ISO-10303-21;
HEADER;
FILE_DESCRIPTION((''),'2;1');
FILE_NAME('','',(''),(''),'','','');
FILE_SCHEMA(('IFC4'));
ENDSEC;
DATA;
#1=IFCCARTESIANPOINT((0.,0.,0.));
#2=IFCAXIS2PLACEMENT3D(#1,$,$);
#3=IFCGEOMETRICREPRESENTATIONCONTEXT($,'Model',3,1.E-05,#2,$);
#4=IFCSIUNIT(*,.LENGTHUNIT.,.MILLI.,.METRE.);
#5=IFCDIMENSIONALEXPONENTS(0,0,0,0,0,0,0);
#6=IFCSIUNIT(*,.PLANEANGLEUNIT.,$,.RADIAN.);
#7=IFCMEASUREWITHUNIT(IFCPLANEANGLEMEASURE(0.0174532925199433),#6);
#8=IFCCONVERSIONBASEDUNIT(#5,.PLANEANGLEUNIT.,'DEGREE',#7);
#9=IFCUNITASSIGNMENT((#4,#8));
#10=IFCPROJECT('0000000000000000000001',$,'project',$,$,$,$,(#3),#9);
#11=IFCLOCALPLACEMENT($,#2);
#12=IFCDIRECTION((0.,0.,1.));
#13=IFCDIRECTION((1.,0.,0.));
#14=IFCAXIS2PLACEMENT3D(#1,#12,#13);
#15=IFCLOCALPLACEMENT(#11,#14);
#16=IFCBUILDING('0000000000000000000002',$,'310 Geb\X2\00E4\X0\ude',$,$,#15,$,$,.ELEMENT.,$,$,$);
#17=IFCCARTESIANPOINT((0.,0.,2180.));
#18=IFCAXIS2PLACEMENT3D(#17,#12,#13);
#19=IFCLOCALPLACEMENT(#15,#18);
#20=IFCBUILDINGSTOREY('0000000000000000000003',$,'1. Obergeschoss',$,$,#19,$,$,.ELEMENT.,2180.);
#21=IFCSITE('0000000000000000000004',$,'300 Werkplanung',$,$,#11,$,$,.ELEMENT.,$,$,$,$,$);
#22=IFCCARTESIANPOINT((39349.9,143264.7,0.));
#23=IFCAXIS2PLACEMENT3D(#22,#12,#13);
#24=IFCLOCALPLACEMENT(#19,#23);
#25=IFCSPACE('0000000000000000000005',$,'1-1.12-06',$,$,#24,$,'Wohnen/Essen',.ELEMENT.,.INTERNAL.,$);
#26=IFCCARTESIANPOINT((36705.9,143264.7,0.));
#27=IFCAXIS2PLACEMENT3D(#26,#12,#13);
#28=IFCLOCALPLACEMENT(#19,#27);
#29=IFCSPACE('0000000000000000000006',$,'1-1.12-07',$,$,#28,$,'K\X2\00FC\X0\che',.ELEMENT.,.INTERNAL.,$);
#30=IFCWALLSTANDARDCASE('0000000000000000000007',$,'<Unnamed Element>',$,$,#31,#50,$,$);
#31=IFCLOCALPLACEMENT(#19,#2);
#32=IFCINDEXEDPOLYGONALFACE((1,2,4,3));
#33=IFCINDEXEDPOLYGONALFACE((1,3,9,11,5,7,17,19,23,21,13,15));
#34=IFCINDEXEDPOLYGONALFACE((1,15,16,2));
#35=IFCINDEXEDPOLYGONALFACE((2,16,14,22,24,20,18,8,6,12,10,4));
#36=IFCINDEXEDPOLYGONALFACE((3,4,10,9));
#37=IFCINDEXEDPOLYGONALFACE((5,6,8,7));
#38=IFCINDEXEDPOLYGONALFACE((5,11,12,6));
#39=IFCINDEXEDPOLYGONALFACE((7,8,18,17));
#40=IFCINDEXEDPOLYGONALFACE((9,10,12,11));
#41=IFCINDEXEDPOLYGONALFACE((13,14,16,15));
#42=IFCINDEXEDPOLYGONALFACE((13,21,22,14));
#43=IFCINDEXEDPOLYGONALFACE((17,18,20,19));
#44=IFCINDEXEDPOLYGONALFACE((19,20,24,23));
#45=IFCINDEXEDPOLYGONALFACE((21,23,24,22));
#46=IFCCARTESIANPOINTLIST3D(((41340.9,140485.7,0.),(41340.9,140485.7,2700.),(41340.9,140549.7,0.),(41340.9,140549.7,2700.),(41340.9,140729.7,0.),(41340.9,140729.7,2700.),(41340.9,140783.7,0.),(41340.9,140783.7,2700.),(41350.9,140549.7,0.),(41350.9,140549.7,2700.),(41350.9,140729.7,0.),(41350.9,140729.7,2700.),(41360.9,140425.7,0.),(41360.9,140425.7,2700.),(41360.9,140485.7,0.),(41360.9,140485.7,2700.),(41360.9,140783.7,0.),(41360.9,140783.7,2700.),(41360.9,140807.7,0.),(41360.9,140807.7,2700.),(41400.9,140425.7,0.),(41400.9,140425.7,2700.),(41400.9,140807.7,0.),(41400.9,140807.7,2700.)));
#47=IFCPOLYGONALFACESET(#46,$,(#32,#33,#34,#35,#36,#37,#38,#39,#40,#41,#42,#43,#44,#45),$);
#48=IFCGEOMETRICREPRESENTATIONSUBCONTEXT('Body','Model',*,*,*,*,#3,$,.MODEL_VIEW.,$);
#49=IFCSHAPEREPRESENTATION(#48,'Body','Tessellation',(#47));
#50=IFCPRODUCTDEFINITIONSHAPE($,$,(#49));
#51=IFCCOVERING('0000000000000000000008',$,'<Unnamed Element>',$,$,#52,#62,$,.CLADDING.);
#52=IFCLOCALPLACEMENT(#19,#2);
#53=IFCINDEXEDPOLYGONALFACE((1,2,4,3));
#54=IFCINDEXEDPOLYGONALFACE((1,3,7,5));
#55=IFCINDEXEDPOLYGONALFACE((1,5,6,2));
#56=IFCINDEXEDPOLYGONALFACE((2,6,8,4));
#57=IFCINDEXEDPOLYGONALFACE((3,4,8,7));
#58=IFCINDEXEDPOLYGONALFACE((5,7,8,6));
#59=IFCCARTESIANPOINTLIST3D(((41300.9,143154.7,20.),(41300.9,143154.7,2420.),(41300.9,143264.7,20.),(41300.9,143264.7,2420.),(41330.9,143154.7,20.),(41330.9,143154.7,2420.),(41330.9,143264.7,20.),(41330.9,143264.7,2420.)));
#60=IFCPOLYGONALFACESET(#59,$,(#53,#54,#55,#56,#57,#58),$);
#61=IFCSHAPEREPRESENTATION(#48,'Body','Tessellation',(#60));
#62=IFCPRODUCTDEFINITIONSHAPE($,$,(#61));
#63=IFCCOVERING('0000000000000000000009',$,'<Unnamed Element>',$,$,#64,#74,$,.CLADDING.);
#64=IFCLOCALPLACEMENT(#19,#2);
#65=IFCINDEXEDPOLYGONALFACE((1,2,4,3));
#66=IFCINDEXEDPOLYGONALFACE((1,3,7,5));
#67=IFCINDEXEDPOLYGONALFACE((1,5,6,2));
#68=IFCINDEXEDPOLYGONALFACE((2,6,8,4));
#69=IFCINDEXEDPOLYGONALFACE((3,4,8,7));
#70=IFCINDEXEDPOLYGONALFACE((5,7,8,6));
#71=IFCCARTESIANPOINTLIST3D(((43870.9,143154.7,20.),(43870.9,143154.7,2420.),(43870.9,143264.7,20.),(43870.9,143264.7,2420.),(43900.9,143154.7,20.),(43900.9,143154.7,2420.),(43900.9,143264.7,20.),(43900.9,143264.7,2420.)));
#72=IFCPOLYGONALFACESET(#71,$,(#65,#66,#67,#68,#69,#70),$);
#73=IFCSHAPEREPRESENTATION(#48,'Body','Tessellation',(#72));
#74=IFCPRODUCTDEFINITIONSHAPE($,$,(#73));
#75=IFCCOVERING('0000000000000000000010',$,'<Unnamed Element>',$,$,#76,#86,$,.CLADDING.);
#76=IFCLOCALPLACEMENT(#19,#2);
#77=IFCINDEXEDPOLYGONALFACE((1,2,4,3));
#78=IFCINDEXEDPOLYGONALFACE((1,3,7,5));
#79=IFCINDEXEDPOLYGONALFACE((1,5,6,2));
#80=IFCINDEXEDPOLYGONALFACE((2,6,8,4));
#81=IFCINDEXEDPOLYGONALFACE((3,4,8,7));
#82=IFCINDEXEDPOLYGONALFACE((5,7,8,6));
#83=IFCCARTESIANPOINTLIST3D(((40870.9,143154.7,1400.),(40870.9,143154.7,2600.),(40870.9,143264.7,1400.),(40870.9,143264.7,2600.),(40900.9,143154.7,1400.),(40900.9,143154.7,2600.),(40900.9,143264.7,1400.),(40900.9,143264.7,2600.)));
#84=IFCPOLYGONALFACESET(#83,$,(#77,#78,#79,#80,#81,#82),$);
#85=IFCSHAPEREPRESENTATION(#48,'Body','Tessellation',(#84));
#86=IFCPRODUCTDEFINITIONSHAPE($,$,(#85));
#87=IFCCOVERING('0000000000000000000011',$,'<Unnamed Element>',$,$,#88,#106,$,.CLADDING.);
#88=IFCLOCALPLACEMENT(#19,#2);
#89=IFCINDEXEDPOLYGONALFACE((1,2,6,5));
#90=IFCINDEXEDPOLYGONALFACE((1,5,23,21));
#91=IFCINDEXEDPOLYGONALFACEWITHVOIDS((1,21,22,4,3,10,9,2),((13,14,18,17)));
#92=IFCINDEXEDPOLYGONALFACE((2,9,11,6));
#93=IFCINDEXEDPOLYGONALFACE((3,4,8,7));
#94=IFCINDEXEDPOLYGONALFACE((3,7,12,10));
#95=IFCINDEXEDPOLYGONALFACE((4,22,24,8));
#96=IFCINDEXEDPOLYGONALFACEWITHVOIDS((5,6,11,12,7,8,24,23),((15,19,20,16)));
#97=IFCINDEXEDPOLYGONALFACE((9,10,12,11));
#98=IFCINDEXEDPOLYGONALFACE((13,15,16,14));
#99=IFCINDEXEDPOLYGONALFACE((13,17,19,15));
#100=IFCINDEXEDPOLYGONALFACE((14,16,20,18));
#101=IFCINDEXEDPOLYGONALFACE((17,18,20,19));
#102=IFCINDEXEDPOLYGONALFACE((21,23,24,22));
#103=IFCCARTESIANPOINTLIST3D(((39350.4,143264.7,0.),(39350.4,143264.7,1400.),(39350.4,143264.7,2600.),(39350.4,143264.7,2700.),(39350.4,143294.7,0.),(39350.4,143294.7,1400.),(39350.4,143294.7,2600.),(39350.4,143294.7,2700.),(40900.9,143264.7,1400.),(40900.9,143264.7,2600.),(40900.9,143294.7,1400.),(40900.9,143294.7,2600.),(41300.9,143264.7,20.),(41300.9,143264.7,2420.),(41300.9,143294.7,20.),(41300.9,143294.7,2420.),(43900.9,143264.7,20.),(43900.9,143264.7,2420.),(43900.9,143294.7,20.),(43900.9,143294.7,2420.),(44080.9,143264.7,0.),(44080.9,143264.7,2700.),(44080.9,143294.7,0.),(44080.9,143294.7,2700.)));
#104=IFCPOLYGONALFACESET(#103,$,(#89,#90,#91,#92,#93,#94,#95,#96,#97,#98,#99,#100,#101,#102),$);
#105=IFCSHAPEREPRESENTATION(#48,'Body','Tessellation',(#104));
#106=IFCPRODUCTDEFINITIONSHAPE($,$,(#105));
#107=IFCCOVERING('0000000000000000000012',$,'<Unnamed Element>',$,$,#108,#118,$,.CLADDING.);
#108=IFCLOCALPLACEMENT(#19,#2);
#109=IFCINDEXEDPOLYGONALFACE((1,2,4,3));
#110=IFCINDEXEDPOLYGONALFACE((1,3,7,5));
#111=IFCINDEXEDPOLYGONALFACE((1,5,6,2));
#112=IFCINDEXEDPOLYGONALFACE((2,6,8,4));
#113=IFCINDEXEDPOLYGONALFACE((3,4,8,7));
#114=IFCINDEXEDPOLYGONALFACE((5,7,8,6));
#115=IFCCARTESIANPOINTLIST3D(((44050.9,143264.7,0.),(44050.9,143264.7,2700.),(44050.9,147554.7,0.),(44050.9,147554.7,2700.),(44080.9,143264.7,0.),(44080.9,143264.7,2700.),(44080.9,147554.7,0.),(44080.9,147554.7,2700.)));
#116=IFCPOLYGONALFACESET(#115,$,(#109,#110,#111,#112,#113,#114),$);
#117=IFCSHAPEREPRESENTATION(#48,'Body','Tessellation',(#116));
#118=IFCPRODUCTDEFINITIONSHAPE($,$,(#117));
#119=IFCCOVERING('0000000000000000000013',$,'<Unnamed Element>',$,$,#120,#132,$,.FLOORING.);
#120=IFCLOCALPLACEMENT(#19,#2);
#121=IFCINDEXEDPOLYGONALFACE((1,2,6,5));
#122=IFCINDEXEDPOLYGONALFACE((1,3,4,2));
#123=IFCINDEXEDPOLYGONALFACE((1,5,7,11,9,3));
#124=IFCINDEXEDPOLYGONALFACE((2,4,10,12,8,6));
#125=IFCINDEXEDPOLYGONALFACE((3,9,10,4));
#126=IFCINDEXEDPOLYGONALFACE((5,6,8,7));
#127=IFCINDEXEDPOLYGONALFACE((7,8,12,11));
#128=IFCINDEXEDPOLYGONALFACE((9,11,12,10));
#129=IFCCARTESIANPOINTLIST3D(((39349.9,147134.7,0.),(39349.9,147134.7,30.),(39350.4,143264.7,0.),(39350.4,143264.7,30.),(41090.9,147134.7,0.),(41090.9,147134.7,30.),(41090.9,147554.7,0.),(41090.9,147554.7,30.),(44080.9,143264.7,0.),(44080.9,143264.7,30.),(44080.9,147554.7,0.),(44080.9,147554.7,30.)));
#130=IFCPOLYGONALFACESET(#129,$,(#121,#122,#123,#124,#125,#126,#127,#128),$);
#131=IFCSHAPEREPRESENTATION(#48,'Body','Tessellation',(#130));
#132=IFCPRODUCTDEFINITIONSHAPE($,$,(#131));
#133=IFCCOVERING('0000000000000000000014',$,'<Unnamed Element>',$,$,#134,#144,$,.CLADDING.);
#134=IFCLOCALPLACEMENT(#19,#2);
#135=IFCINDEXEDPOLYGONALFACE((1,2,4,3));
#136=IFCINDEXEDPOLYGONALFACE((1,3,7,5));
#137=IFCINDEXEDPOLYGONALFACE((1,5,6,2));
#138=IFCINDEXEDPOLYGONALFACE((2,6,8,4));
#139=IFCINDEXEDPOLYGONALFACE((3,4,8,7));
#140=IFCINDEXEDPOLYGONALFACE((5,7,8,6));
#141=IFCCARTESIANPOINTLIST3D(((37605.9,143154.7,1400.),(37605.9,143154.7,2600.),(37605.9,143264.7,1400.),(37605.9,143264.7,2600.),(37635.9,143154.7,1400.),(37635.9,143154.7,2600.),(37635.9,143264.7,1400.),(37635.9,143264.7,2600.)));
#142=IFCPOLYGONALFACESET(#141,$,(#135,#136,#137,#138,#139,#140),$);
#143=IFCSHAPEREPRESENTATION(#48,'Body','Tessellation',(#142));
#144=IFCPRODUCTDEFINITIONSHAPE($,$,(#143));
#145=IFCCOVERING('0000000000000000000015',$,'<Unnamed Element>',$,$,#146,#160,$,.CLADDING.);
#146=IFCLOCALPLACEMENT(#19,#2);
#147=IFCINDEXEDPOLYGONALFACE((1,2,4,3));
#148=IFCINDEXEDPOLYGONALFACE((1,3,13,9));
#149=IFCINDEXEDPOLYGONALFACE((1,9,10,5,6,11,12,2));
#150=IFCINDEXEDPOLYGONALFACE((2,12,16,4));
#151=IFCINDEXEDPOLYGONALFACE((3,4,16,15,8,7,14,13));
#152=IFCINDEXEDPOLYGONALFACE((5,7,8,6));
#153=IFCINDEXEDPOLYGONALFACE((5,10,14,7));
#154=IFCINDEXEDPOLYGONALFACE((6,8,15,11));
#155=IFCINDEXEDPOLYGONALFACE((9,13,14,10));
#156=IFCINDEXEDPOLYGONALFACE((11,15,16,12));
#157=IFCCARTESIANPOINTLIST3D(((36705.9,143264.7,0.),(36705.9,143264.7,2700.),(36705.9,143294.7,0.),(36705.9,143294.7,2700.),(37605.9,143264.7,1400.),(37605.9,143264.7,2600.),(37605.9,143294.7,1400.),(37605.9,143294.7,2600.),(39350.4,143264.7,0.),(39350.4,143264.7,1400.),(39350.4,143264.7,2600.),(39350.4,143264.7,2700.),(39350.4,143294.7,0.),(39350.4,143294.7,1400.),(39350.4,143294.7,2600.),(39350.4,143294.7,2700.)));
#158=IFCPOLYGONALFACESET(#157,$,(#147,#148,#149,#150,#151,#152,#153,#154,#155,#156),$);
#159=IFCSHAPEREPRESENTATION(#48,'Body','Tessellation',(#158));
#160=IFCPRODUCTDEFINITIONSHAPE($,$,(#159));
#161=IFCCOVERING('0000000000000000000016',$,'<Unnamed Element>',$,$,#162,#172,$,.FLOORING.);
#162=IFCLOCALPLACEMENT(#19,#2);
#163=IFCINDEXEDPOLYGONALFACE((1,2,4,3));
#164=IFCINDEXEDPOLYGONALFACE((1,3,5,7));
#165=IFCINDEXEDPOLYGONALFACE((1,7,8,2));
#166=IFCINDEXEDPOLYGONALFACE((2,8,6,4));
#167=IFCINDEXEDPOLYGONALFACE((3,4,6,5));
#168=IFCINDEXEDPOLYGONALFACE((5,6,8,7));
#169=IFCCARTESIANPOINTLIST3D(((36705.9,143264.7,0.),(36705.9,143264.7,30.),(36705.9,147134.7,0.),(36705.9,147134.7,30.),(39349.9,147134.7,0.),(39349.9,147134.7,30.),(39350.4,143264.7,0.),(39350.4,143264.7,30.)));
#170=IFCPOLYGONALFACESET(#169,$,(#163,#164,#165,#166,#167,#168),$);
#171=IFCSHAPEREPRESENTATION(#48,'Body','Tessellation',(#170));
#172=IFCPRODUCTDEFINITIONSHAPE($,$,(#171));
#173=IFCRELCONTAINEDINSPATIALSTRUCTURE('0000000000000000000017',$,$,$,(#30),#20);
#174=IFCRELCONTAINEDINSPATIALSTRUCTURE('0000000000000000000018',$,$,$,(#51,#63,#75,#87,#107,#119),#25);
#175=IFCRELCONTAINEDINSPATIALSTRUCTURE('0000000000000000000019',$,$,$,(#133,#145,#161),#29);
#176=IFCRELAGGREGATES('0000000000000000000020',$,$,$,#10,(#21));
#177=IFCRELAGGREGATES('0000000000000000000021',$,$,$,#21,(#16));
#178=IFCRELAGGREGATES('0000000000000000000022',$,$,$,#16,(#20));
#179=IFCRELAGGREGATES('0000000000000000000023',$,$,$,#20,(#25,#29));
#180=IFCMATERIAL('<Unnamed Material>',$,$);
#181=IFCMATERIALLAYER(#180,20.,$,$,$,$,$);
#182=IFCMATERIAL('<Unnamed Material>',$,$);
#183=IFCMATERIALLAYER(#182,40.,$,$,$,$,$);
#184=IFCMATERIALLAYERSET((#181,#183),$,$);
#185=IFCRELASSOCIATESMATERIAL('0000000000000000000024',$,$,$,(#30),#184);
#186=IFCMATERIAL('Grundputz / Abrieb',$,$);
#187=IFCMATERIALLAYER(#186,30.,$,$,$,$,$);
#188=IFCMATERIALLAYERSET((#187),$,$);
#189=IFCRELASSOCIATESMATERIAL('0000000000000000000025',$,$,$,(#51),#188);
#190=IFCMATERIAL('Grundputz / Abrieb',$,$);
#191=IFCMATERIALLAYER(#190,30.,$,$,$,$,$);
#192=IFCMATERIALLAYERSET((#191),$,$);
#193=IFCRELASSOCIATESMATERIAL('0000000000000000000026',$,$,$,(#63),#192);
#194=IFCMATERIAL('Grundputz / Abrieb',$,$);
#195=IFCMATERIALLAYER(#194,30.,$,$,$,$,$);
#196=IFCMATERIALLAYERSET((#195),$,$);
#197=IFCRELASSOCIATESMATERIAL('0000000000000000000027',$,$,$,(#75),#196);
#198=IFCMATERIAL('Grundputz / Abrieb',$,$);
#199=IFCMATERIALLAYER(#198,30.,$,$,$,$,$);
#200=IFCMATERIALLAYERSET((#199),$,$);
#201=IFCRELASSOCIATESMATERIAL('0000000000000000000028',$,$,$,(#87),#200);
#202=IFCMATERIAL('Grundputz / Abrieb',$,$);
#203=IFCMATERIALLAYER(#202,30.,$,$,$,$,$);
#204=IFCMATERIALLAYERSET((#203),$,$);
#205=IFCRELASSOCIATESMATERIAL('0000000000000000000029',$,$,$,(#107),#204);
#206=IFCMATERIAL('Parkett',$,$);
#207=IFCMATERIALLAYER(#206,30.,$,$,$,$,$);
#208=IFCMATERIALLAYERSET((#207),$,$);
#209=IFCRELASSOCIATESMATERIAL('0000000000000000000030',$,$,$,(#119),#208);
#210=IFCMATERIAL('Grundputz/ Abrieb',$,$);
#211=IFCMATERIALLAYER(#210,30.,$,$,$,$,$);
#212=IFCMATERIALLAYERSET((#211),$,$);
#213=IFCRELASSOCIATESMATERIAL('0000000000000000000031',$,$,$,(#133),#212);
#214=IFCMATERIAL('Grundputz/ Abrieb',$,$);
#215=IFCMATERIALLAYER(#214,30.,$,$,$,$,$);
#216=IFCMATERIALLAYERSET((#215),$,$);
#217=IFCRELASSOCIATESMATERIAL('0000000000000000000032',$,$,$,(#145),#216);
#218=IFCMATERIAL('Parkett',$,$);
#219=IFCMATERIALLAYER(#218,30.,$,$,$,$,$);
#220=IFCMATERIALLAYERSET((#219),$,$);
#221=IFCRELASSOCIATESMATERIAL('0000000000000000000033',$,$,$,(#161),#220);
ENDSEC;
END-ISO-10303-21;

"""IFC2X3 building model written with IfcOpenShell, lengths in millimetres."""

from ifc_helpers import new_model, entity, si_unit, converted_unit, frame, frame_2d, origin, origin_with_axes, place, context, subcontext, project, spatial, polyline, rectangle, outline, extrude, material, layer, layer_set, layer_usage, element, save


model = new_model("IFC2X3")

# Units and contexts
model_context = context("Model", 3, precision=1e-05, world=origin())
body_context = subcontext(model_context, "Body", "Model", "MODEL_VIEW")
ifc_project = project(units=[si_unit("LENGTHUNIT", "METRE", prefix="MILLI"), converted_unit("PLANEANGLEUNIT", "DEGREE", entity("IfcPlaneAngleMeasure", 0.0174532925199433), si_unit("PLANEANGLEUNIT", "RADIAN"), dimensions=[0, 0, 0, 0, 0, 0, 0])], contexts=[model_context])

# Site, building, storey
site_placement = place(None, origin())
site = spatial("IfcSite", under=ifc_project, at=site_placement, Name="300 Werkplanung", CompositionType="ELEMENT")
building_placement = place(site_placement, origin_with_axes())
building = spatial("IfcBuilding", under=site, at=building_placement, Name="310 Gebäude", CompositionType="ELEMENT")
storey_placement = place(building_placement, frame((0.0, 0.0, 2180.0), z_axis=(0.0, 0.0, 1.0), x_axis=(1.0, 0.0, 0.0)))
storey = spatial("IfcBuildingStorey", under=building, at=storey_placement, Name="1. Obergeschoss", CompositionType="ELEMENT", Elevation=2180.0)

# Wall
ifc_material_1 = material(Name="<Unnamed Material>")
ifc_layer_1 = layer(ifc_material_1, 20.0)
ifc_material_2 = material(Name="<Unnamed Material>")
ifc_layer_2 = layer(ifc_material_2, 40.0)
ifc_layer_set_1 = layer_set([ifc_layer_1, ifc_layer_2])
ifc_layer_usage_1 = layer_usage(ifc_layer_set_1, "AXIS2", "POSITIVE", -60.0)
wall_1_placement = place(storey_placement, frame((41340.9, 140783.7, 0.0), z_axis=(0.0, 0.0, 1.0), x_axis=(0.0, -1.0, 0.0)))
element("IfcWallStandardCase", 1, at=wall_1_placement, inside=storey, material=ifc_layer_usage_1, Name="<Unnamed Element>", context=body_context, shape_type="SweptSolid", body=[
    extrude(outline(polyline([(234.0, 0.0), (298.0, 0.0), (298.0, 20.0), (358.0, 20.0), (358.0, 60.0), (-24.0, 60.0), (-24.0, 20.0), (0.0, 20.0), (0.0, 0.0), (54.0, 0.0), (54.0, 10.0), (234.0, 10.0), (234.0, 0.0)])), origin_with_axes(), (0.0, 0.0, 1.0), 2700.0),
])

# Shared definitions
space_1_placement = place(storey_placement, frame((39349.9, 143264.7, 0.0), z_axis=(0.0, 0.0, 1.0), x_axis=(1.0, 0.0, 0.0)))
space_1 = spatial("IfcSpace", under=storey, at=space_1_placement, Name="1-1.12-06", LongName="Wohnen/Essen", CompositionType="ELEMENT", InteriorOrExteriorSpace="INTERNAL")

# Coverings
ifc_material_3 = material(Name="Grundputz / Abrieb")
ifc_layer_3 = layer(ifc_material_3, 30.0)
ifc_layer_set_2 = layer_set([ifc_layer_3])
ifc_layer_usage_2 = layer_usage(ifc_layer_set_2, "AXIS3", "POSITIVE", 0.0)
covering_1_placement = place(space_1_placement, frame((1951.0, 0.0, 20.0), z_axis=(0.0, 0.0, 1.0), x_axis=(0.0, -1.0, 0.0)))
element("IfcCovering", 2, at=covering_1_placement, inside=space_1, material=ifc_layer_usage_2, Name="<Unnamed Element>", PredefinedType="CLADDING", context=body_context, shape_type="SweptSolid", body=[
    extrude(rectangle(XDim=2400.0, YDim=110.0, at=frame_2d((-55.0, 1200.0), x_axis=(0.0, 1.0))), frame((110.0, 0.0, 2400.0), z_axis=(0.0, 1.0, 0.0), x_axis=(1.0, 0.0, 0.0)), (0.0, 0.0, 1.0), 30.0),
])
ifc_material_4 = material(Name="Grundputz / Abrieb")
ifc_layer_4 = layer(ifc_material_4, 30.0)
ifc_layer_set_3 = layer_set([ifc_layer_4])
ifc_layer_usage_3 = layer_usage(ifc_layer_set_3, "AXIS3", "POSITIVE", 0.0)
covering_2_placement = place(space_1_placement, frame((4551.0, -110.0, 20.0), z_axis=(0.0, 0.0, 1.0), x_axis=(0.0, 1.0, 0.0)))
element("IfcCovering", 3, at=covering_2_placement, inside=space_1, material=ifc_layer_usage_3, Name="<Unnamed Element>", PredefinedType="CLADDING", context=body_context, shape_type="SweptSolid", body=[
    extrude(rectangle(XDim=2400.0, YDim=110.0, at=frame_2d((-55.0, 1200.0), x_axis=(0.0, 1.0))), frame((110.0, 0.0, 2400.0), z_axis=(0.0, 1.0, 0.0), x_axis=(1.0, 0.0, 0.0)), (0.0, 0.0, 1.0), 30.0),
])
ifc_material_5 = material(Name="Grundputz / Abrieb")
ifc_layer_5 = layer(ifc_material_5, 30.0)
ifc_layer_set_4 = layer_set([ifc_layer_5])
ifc_layer_usage_4 = layer_usage(ifc_layer_set_4, "AXIS3", "POSITIVE", 0.0)
covering_3_placement = place(space_1_placement, frame((1551.0, -110.0, 1400.0), z_axis=(0.0, 0.0, 1.0), x_axis=(0.0, 1.0, 0.0)))
element("IfcCovering", 4, at=covering_3_placement, inside=space_1, material=ifc_layer_usage_4, Name="<Unnamed Element>", PredefinedType="CLADDING", context=body_context, shape_type="SweptSolid", body=[
    extrude(rectangle(XDim=1200.0, YDim=110.0, at=frame_2d((-55.0, 600.0), x_axis=(0.0, 1.0))), frame((110.0, 0.0, 1200.0), z_axis=(0.0, 1.0, 0.0), x_axis=(1.0, 0.0, 0.0)), (0.0, 0.0, 1.0), 30.0),
])
ifc_material_6 = material(Name="Grundputz / Abrieb")
ifc_layer_6 = layer(ifc_material_6, 30.0)
ifc_layer_set_5 = layer_set([ifc_layer_6])
ifc_layer_usage_5 = layer_usage(ifc_layer_set_5, "AXIS3", "POSITIVE", 0.0)
covering_4_placement = place(space_1_placement, frame((0.5, 0.0, 0.0), z_axis=(0.0, 0.0, 1.0), x_axis=(1.0, 0.0, 0.0)))
element("IfcCovering", 5, at=covering_4_placement, inside=space_1, material=ifc_layer_usage_5, Name="<Unnamed Element>", PredefinedType="CLADDING", context=body_context, shape_type="SweptSolid", body=[
    extrude(outline(polyline([(4730.5, 0.0), (4730.5, -2700.0), (0.0, -2700.0), (0.0, -2600.0), (1550.5, -2600.0), (1550.5, -1400.0), (0.0, -1400.0), (0.0, 0.0), (4730.5, 0.0)]), holes=[polyline([(4550.5, -20.0), (1950.5, -20.0), (1950.5, -2420.0), (4550.5, -2420.0), (4550.5, -20.0)])]), frame((0.0, 0.0, 0.0), z_axis=(0.0, 1.0, 0.0), x_axis=(1.0, 0.0, 0.0)), (0.0, 0.0, 1.0), 30.0),
])
ifc_material_7 = material(Name="Grundputz / Abrieb")
ifc_layer_7 = layer(ifc_material_7, 30.0)
ifc_layer_set_6 = layer_set([ifc_layer_7])
ifc_layer_usage_6 = layer_usage(ifc_layer_set_6, "AXIS3", "POSITIVE", 0.0)
covering_5_placement = place(space_1_placement, frame((4731.0, 0.0, 0.0), z_axis=(0.0, 0.0, 1.0), x_axis=(0.0, 1.0, 0.0)))
element("IfcCovering", 6, at=covering_5_placement, inside=space_1, material=ifc_layer_usage_6, Name="<Unnamed Element>", PredefinedType="CLADDING", context=body_context, shape_type="SweptSolid", body=[
    extrude(rectangle(XDim=2700.0, YDim=4290.0, at=frame_2d((-2145.0, 1350.0), x_axis=(0.0, 1.0))), frame((4290.0, 0.0, 2700.0), z_axis=(0.0, 1.0, 0.0), x_axis=(1.0, 0.0, 0.0)), (0.0, 0.0, 1.0), 30.0),
])
ifc_material_8 = material(Name="Parkett")
ifc_layer_8 = layer(ifc_material_8, 30.0)
ifc_layer_set_7 = layer_set([ifc_layer_8])
ifc_layer_usage_7 = layer_usage(ifc_layer_set_7, "AXIS3", "POSITIVE", 0.0)
covering_6_placement = place(space_1_placement, origin_with_axes())
element("IfcCovering", 7, at=covering_6_placement, inside=space_1, material=ifc_layer_usage_7, Name="<Unnamed Element>", PredefinedType="FLOORING", context=body_context, shape_type="SweptSolid", body=[
    extrude(outline(polyline([(1741.0, 3870.0), (0.0, 3870.0), (0.5, 0.0), (4731.0, 0.0), (4731.0, 4290.0), (1741.0, 4290.0), (1741.0, 3870.0)])), origin_with_axes(), (0.0, 0.0, 1.0), 30.0),
])

# Shared definitions
space_2_placement = place(storey_placement, frame((36705.9, 143264.7, 0.0), z_axis=(0.0, 0.0, 1.0), x_axis=(1.0, 0.0, 0.0)))
space_2 = spatial("IfcSpace", under=storey, at=space_2_placement, Name="1-1.12-07", LongName="Küche", CompositionType="ELEMENT", InteriorOrExteriorSpace="INTERNAL")

# Coverings
ifc_material_9 = material(Name="Grundputz/ Abrieb")
ifc_layer_9 = layer(ifc_material_9, 30.0)
ifc_layer_set_8 = layer_set([ifc_layer_9])
ifc_layer_usage_8 = layer_usage(ifc_layer_set_8, "AXIS3", "POSITIVE", 0.0)
covering_7_placement = place(space_2_placement, frame((900.0, 0.0, 1400.0), z_axis=(0.0, 0.0, 1.0), x_axis=(0.0, -1.0, 0.0)))
element("IfcCovering", 8, at=covering_7_placement, inside=space_2, material=ifc_layer_usage_8, Name="<Unnamed Element>", PredefinedType="CLADDING", context=body_context, shape_type="SweptSolid", body=[
    extrude(rectangle(XDim=1200.0, YDim=110.0, at=frame_2d((-55.0, 600.0), x_axis=(0.0, 1.0))), frame((110.0, 0.0, 1200.0), z_axis=(0.0, 1.0, 0.0), x_axis=(1.0, 0.0, 0.0)), (0.0, 0.0, 1.0), 30.0),
])
ifc_material_10 = material(Name="Grundputz/ Abrieb")
ifc_layer_10 = layer(ifc_material_10, 30.0)
ifc_layer_set_9 = layer_set([ifc_layer_10])
ifc_layer_usage_9 = layer_usage(ifc_layer_set_9, "AXIS3", "POSITIVE", 0.0)
covering_8_placement = place(space_2_placement, frame((0.0, 0.0, 0.0), z_axis=(0.0, 0.0, 1.0), x_axis=(1.0, 0.0, 0.0)))
element("IfcCovering", 9, at=covering_8_placement, inside=space_2, material=ifc_layer_usage_9, Name="<Unnamed Element>", PredefinedType="CLADDING", context=body_context, shape_type="SweptSolid", body=[
    extrude(outline(polyline([(2644.5, 0.0), (2644.5, -1400.0), (900.0, -1400.0), (900.0, -2600.0), (2644.5, -2600.0), (2644.5, -2700.0), (0.0, -2700.0), (0.0, 0.0), (2644.5, 0.0)])), frame((0.0, 0.0, 0.0), z_axis=(0.0, 1.0, 0.0), x_axis=(1.0, 0.0, 0.0)), (0.0, 0.0, 1.0), 30.0),
])
ifc_material_11 = material(Name="Parkett")
ifc_layer_11 = layer(ifc_material_11, 30.0)
ifc_layer_set_10 = layer_set([ifc_layer_11])
ifc_layer_usage_10 = layer_usage(ifc_layer_set_10, "AXIS3", "POSITIVE", 0.0)
covering_9_placement = place(space_2_placement, origin_with_axes())
element("IfcCovering", 10, at=covering_9_placement, inside=space_2, material=ifc_layer_usage_10, Name="<Unnamed Element>", PredefinedType="FLOORING", context=body_context, shape_type="SweptSolid", body=[
    extrude(outline(polyline([(2644.0, 3870.0), (0.0, 3870.0), (0.0, 0.0), (2644.5, 0.0), (2644.0, 3870.0)])), origin_with_axes(), (0.0, 0.0, 1.0), 30.0),
])

save(model, "model.ifc")
